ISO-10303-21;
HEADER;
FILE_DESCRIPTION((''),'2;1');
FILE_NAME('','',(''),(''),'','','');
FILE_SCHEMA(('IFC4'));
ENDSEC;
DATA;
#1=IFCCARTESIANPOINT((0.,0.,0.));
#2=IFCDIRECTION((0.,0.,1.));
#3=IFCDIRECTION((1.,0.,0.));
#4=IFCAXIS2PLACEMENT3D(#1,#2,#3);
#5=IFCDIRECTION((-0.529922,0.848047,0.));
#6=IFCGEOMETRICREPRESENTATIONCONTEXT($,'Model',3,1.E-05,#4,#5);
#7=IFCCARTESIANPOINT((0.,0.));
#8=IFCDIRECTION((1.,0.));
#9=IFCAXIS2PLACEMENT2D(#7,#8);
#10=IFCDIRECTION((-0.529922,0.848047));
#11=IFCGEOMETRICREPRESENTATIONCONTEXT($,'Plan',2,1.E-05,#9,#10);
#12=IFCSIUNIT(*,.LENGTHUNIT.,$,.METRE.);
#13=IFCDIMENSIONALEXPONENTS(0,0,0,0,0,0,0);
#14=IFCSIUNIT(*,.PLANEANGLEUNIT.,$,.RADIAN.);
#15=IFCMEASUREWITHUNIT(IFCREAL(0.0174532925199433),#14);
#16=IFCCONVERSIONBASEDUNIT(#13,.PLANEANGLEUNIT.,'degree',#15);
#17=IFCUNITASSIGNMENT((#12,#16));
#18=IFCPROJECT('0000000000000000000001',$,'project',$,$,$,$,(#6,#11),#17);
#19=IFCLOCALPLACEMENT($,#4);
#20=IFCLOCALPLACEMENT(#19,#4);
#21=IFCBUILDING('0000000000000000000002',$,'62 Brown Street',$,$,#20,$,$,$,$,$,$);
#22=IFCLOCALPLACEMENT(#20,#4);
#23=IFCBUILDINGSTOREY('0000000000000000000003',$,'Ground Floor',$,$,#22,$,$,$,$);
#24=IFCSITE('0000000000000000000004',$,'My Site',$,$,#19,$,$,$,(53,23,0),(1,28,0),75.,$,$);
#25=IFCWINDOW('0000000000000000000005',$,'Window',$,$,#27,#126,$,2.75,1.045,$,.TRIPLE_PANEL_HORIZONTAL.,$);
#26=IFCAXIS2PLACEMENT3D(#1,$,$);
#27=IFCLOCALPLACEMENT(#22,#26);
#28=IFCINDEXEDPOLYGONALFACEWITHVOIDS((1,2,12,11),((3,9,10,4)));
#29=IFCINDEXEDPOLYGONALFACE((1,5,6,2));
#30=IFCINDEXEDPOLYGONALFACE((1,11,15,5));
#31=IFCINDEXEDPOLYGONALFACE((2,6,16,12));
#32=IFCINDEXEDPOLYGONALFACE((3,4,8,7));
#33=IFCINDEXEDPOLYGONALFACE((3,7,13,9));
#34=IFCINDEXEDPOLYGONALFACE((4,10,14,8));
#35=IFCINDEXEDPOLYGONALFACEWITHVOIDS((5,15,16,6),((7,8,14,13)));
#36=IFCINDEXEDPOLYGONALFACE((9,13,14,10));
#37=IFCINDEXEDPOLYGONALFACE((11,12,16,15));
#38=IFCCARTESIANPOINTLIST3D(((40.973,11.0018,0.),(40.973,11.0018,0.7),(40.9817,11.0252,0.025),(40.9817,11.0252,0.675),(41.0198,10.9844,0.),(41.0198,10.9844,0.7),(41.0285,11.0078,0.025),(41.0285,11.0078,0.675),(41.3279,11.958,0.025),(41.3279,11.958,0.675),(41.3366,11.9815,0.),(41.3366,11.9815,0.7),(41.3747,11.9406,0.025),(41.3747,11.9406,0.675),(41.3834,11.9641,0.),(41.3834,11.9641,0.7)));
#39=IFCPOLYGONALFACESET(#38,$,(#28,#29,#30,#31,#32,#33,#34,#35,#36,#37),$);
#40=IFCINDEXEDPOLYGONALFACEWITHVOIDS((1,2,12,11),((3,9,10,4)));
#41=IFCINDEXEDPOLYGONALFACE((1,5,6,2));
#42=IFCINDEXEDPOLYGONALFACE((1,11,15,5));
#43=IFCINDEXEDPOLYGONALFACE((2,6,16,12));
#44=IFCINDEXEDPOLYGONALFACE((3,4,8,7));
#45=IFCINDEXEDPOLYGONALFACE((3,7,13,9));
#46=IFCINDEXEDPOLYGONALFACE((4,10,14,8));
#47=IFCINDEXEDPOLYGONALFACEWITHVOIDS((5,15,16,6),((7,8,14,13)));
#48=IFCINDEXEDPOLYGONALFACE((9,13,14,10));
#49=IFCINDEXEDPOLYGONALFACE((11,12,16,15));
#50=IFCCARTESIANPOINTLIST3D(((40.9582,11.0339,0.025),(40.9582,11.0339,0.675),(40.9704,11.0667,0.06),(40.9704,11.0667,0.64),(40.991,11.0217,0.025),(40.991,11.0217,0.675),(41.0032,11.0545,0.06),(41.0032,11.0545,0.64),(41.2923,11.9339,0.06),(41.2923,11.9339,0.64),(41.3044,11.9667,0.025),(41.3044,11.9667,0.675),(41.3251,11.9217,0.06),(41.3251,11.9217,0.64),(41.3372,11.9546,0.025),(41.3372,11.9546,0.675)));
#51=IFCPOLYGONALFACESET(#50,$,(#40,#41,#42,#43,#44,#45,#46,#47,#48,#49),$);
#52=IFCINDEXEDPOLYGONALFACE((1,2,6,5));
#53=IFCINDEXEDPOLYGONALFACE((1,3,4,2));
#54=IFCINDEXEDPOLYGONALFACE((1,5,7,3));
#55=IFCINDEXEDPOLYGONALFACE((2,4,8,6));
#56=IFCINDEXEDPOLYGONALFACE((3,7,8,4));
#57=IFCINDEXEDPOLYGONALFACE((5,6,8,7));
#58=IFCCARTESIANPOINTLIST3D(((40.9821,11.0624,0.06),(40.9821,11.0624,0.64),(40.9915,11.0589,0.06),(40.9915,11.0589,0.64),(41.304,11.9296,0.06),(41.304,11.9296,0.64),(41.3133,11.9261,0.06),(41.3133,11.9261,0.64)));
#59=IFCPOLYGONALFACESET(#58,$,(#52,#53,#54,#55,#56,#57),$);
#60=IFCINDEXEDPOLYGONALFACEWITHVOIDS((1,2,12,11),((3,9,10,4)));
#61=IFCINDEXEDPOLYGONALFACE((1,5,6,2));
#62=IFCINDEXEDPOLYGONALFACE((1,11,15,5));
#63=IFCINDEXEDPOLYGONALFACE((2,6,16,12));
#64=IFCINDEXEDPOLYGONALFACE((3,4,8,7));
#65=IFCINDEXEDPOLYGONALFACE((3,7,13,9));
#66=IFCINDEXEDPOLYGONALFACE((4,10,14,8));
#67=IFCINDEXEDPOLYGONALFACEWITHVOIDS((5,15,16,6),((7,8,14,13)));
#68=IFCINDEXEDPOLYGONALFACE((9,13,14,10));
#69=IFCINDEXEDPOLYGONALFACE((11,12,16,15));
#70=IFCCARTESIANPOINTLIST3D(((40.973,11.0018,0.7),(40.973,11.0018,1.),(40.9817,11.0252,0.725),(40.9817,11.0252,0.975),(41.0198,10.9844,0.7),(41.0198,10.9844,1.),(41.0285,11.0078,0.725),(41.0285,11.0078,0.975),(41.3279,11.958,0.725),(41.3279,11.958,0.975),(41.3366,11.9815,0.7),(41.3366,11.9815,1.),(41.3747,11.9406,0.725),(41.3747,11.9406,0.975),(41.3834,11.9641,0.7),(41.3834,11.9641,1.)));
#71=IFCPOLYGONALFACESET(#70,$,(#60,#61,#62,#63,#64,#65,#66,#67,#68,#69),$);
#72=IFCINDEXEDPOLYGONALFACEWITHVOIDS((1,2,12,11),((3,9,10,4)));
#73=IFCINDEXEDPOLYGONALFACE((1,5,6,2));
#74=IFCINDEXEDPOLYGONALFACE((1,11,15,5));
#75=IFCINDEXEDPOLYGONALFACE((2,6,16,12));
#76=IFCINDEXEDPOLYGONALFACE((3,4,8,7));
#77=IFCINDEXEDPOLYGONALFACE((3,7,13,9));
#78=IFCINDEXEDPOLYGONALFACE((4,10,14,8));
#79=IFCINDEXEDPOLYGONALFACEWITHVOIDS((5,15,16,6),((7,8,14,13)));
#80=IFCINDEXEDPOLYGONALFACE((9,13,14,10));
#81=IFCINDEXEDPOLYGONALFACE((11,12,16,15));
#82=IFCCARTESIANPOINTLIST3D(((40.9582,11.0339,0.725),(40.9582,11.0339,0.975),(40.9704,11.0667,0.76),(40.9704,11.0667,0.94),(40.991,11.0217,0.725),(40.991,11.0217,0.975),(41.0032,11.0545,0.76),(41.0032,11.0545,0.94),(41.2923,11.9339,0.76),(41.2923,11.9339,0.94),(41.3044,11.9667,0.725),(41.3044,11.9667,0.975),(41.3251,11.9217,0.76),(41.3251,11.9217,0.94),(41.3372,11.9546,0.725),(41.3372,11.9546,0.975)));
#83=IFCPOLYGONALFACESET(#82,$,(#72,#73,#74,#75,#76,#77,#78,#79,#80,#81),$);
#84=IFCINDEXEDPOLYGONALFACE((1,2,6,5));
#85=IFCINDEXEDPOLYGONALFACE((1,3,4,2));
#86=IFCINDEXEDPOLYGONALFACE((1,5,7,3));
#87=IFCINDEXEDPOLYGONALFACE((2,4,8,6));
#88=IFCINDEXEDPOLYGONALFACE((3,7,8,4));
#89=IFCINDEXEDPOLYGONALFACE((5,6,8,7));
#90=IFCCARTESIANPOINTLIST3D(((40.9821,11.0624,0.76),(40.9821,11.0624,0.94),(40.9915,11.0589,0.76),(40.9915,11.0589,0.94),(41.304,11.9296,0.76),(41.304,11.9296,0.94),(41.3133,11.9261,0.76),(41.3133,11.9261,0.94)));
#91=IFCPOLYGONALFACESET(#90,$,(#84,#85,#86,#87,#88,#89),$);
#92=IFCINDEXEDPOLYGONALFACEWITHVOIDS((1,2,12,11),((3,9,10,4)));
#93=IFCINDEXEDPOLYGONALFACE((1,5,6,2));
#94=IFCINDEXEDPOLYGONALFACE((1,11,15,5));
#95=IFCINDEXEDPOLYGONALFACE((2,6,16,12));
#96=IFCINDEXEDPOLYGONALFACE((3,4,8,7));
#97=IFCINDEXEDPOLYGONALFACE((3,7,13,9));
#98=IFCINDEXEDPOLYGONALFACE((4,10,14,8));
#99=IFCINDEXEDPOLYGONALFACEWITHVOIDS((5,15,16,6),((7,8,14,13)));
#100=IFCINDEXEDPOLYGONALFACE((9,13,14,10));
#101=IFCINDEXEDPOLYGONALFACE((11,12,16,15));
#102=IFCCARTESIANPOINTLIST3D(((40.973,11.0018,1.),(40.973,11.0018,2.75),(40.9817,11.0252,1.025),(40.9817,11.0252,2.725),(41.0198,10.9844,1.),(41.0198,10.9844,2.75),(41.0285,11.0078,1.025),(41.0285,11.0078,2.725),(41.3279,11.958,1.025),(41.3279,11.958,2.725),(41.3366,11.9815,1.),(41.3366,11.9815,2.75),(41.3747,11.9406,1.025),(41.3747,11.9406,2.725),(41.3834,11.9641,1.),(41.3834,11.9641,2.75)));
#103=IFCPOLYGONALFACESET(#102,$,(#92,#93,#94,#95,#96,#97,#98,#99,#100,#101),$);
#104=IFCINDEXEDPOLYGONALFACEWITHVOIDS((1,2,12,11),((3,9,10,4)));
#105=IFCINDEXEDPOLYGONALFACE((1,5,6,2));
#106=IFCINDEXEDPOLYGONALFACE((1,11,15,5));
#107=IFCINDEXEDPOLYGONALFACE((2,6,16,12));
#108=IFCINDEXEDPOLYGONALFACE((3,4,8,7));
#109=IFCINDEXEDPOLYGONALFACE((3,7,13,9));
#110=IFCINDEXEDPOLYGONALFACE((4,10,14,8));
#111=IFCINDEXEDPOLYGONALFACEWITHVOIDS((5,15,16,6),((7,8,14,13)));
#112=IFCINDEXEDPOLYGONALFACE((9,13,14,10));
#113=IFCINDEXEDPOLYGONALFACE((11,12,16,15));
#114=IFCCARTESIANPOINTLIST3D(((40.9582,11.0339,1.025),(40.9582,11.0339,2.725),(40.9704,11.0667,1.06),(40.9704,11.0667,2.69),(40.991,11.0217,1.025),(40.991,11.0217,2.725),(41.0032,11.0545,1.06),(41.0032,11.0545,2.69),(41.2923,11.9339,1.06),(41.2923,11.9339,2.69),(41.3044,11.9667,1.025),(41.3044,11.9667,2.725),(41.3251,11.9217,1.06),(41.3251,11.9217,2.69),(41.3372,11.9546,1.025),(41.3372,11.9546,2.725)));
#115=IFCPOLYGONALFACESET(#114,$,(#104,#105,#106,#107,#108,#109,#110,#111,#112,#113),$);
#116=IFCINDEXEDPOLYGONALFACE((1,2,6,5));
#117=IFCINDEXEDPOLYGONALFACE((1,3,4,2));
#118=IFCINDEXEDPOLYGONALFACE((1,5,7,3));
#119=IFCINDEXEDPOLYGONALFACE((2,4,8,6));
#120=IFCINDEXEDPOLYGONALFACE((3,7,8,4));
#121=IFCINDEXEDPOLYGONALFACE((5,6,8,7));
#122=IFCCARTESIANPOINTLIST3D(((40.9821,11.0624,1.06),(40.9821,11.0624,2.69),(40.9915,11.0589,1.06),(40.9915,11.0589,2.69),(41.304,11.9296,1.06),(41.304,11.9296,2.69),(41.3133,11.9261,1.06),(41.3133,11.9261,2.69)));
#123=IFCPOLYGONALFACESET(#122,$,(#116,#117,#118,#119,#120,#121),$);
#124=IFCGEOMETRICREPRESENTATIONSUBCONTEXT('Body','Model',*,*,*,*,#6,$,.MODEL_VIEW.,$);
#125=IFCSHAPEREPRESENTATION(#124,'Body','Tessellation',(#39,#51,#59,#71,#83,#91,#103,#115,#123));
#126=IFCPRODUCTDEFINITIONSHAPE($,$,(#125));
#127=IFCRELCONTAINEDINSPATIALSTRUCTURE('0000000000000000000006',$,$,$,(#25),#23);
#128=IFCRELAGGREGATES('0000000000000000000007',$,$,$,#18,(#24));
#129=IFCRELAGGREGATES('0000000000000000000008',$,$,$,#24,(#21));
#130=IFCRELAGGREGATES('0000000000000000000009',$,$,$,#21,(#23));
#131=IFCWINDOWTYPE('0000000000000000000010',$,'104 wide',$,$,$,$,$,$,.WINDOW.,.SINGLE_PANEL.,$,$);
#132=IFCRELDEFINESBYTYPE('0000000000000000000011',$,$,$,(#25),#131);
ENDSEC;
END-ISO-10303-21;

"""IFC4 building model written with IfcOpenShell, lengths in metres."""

from ifc_helpers import new_model, entity, si_unit, converted_unit, direction, frame, origin_with_axes, origin_2d_with_axis, place, context, subcontext, project, spatial, line, indexed_curve, outline, extrude, shape, source, transform, mapped, type_object, type_shapes, element, save


model = new_model("IFC4")

# Units and contexts
model_context = context("Model", 3, precision=1e-05, world=origin_with_axes(), true_north=direction((-0.529922, 0.848047, 0.0)))
plan_context = context("Plan", 2, precision=1e-05, world=origin_2d_with_axis(), true_north=direction((-0.529922, 0.848047)))
body_context_1 = subcontext(model_context, "Body", "Model", "MODEL_VIEW")
body_context_2 = subcontext(plan_context, "Body", "Plan", "PLAN_VIEW")
ifc_project = project(units=[si_unit("LENGTHUNIT", "METRE"), converted_unit("PLANEANGLEUNIT", "degree", entity("IfcReal", 0.0174532925199433), si_unit("PLANEANGLEUNIT", "RADIAN"), dimensions=[0, 0, 0, 0, 0, 0, 0])], contexts=[model_context, plan_context])

# Site, building, storey
site_placement = place(None, origin_with_axes())
site = spatial("IfcSite", under=ifc_project, at=site_placement, Name="My Site", RefLatitude=(53, 23, 0), RefLongitude=(1, 28, 0), RefElevation=75.0)
building_placement = place(site_placement, origin_with_axes())
building = spatial("IfcBuilding", under=site, at=building_placement, Name="62 Brown Street")
storey_placement = place(building_placement, origin_with_axes())
storey = spatial("IfcBuildingStorey", under=building, at=storey_placement, Name="Ground Floor")

# Window
window_type_1 = type_object("IfcWindowType", Name="104 wide", PartitioningType="SINGLE_PANEL", PredefinedType="WINDOW")
shared_shape_1 = source(origin_with_axes(), body_context_1, "Body", "SweptSolid", [
    extrude(outline(indexed_curve([(0.0, 0.0), (1.045, 0.0), (1.045, 0.7), (0.0, 0.7)], segments=[line(1, 2, 3, 4, 1)]), holes=[indexed_curve([(0.025, 0.025), (1.02, 0.025), (1.02, 0.675), (0.025, 0.675)], segments=[line(1, 2, 3, 4, 1)])]), frame((0.0, 0.15, 0.0), z_axis=(0.0, -1.0, 0.0), x_axis=(1.0, 0.0, 0.0)), (0.0, 0.0, -1.0), 0.05),
    extrude(outline(indexed_curve([(0.0, 0.0), (0.995, 0.0), (0.995, 0.65), (0.0, 0.65)], segments=[line(1, 2, 3, 4, 1)]), holes=[indexed_curve([(0.035, 0.035), (0.96, 0.035), (0.96, 0.615), (0.035, 0.615)], segments=[line(1, 2, 3, 4, 1)])]), frame((0.025, 0.19, 0.025), z_axis=(0.0, -1.0, 0.0), x_axis=(1.0, 0.0, 0.0)), (0.0, 0.0, -1.0), 0.035),
    extrude(outline(indexed_curve([(0.035, 0.035), (0.96, 0.035), (0.96, 0.615), (0.035, 0.615)], segments=[line(1, 2, 3, 4, 1)])), frame((0.025, 0.2025, 0.025), z_axis=(0.0, -1.0, 0.0), x_axis=(1.0, 0.0, 0.0)), (0.0, 0.0, -1.0), 0.01),
    extrude(outline(indexed_curve([(0.0, 0.0), (1.045, 0.0), (1.045, 0.3), (0.0, 0.3)], segments=[line(1, 2, 3, 4, 1)]), holes=[indexed_curve([(0.025, 0.025), (1.02, 0.025), (1.02, 0.275), (0.025, 0.275)], segments=[line(1, 2, 3, 4, 1)])]), frame((0.0, 0.15, 0.7), z_axis=(0.0, -1.0, 0.0), x_axis=(1.0, 0.0, 0.0)), (0.0, 0.0, -1.0), 0.05),
    extrude(outline(indexed_curve([(0.0, 0.0), (0.995, 0.0), (0.995, 0.25), (0.0, 0.25)], segments=[line(1, 2, 3, 4, 1)]), holes=[indexed_curve([(0.035, 0.035), (0.96, 0.035), (0.96, 0.215), (0.035, 0.215)], segments=[line(1, 2, 3, 4, 1)])]), frame((0.025, 0.19, 0.725), z_axis=(0.0, -1.0, 0.0), x_axis=(1.0, 0.0, 0.0)), (0.0, 0.0, -1.0), 0.035),
    extrude(outline(indexed_curve([(0.035, 0.035), (0.96, 0.035), (0.96, 0.215), (0.035, 0.215)], segments=[line(1, 2, 3, 4, 1)])), frame((0.025, 0.2025, 0.725), z_axis=(0.0, -1.0, 0.0), x_axis=(1.0, 0.0, 0.0)), (0.0, 0.0, -1.0), 0.01),
    extrude(outline(indexed_curve([(0.0, 0.0), (1.045, 0.0), (1.045, 1.75), (0.0, 1.75)], segments=[line(1, 2, 3, 4, 1)]), holes=[indexed_curve([(0.025, 0.025), (1.02, 0.025), (1.02, 1.725), (0.025, 1.725)], segments=[line(1, 2, 3, 4, 1)])]), frame((0.0, 0.15, 1.0), z_axis=(0.0, -1.0, 0.0), x_axis=(1.0, 0.0, 0.0)), (0.0, 0.0, -1.0), 0.05),
    extrude(outline(indexed_curve([(0.0, 0.0), (0.995, 0.0), (0.995, 1.7), (0.0, 1.7)], segments=[line(1, 2, 3, 4, 1)]), holes=[indexed_curve([(0.035, 0.035), (0.96, 0.035), (0.96, 1.665), (0.035, 1.665)], segments=[line(1, 2, 3, 4, 1)])]), frame((0.025, 0.19, 1.025), z_axis=(0.0, -1.0, 0.0), x_axis=(1.0, 0.0, 0.0)), (0.0, 0.0, -1.0), 0.035),
    extrude(outline(indexed_curve([(0.035, 0.035), (0.96, 0.035), (0.96, 1.665), (0.035, 1.665)], segments=[line(1, 2, 3, 4, 1)])), frame((0.025, 0.2025, 1.025), z_axis=(0.0, -1.0, 0.0), x_axis=(1.0, 0.0, 0.0)), (0.0, 0.0, -1.0), 0.01),
])
shared_shape_2 = source(origin_with_axes(), body_context_2, "Body", "Curve2D", [
    entity("IfcIndexedPolyCurve", entity("IfcCartesianPointList2D", [[0.025, 0.15], [1.02, 0.15]])),
    entity("IfcIndexedPolyCurve", entity("IfcCartesianPointList2D", [[0.0, 0.2], [0.025, 0.2], [0.025, 0.15], [0.0, 0.15]]), [entity("IfcLineIndex", [1, 2, 3, 4, 1])]),
    entity("IfcIndexedPolyCurve", entity("IfcCartesianPointList2D", [[1.045, 0.2], [1.02, 0.2], [1.02, 0.15], [1.045, 0.15]]), [entity("IfcLineIndex", [1, 2, 3, 4, 1])]),
    entity("IfcIndexedPolyCurve", entity("IfcCartesianPointList2D", [[0.025, 0.19], [0.06, 0.19], [0.06, 0.225], [0.025, 0.225]]), [entity("IfcLineIndex", [1, 2, 3, 4, 1])]),
    entity("IfcIndexedPolyCurve", entity("IfcCartesianPointList2D", [[1.02, 0.19], [0.985, 0.19], [0.985, 0.225], [1.02, 0.225]]), [entity("IfcLineIndex", [1, 2, 3, 4, 1])]),
    entity("IfcIndexedPolyCurve", entity("IfcCartesianPointList2D", [[0.06, 0.19], [0.985, 0.19]])),
    entity("IfcIndexedPolyCurve", entity("IfcCartesianPointList2D", [[0.06, 0.225], [0.985, 0.225]])),
    entity("IfcIndexedPolyCurve", entity("IfcCartesianPointList2D", [[0.06, 0.2075], [0.985, 0.2075]])),
])
type_shapes(window_type_1, [shared_shape_1, shared_shape_2])
placement_1 = place(storey_placement, frame((39.024, 5.1755, 0.0), z_axis=(0.0, 0.0, 1.0), x_axis=(0.347944, 0.937515, 0.0)))
placement_2 = place(placement_1, frame((6.1404, 0.0, 0.0), z_axis=(0.0, 0.0, 1.0), x_axis=(1.0, 0.0, 0.0)))
window_1_placement = place(placement_2, frame((0.0, 0.0, 0.0), z_axis=(0.0, 0.0, 1.0), x_axis=(1.0, 0.0, 0.0)))
element("IfcWindow", 1, at=window_1_placement, inside=storey, type_object=window_type_1, Name="Window", OverallHeight=2.75, OverallWidth=1.045, PartitioningType="TRIPLE_PANEL_HORIZONTAL", shapes=[
    shape(body_context_1, "Body", "MappedRepresentation", [mapped(shared_shape_1, transform((0.0, 0.0, 0.0), x_axis=(1.0, 0.0, 0.0), y_axis=(0.0, 1.0, 0.0), z_axis=(0.0, 0.0, 1.0), scale=1.0))]),
    shape(body_context_2, "Body", "MappedRepresentation", [mapped(shared_shape_2, transform((0.0, 0.0, 0.0), x_axis=(1.0, 0.0, 0.0), y_axis=(0.0, 1.0, 0.0), z_axis=(0.0, 0.0, 1.0), scale=1.0))]),
])

save(model, "model.ifc")
